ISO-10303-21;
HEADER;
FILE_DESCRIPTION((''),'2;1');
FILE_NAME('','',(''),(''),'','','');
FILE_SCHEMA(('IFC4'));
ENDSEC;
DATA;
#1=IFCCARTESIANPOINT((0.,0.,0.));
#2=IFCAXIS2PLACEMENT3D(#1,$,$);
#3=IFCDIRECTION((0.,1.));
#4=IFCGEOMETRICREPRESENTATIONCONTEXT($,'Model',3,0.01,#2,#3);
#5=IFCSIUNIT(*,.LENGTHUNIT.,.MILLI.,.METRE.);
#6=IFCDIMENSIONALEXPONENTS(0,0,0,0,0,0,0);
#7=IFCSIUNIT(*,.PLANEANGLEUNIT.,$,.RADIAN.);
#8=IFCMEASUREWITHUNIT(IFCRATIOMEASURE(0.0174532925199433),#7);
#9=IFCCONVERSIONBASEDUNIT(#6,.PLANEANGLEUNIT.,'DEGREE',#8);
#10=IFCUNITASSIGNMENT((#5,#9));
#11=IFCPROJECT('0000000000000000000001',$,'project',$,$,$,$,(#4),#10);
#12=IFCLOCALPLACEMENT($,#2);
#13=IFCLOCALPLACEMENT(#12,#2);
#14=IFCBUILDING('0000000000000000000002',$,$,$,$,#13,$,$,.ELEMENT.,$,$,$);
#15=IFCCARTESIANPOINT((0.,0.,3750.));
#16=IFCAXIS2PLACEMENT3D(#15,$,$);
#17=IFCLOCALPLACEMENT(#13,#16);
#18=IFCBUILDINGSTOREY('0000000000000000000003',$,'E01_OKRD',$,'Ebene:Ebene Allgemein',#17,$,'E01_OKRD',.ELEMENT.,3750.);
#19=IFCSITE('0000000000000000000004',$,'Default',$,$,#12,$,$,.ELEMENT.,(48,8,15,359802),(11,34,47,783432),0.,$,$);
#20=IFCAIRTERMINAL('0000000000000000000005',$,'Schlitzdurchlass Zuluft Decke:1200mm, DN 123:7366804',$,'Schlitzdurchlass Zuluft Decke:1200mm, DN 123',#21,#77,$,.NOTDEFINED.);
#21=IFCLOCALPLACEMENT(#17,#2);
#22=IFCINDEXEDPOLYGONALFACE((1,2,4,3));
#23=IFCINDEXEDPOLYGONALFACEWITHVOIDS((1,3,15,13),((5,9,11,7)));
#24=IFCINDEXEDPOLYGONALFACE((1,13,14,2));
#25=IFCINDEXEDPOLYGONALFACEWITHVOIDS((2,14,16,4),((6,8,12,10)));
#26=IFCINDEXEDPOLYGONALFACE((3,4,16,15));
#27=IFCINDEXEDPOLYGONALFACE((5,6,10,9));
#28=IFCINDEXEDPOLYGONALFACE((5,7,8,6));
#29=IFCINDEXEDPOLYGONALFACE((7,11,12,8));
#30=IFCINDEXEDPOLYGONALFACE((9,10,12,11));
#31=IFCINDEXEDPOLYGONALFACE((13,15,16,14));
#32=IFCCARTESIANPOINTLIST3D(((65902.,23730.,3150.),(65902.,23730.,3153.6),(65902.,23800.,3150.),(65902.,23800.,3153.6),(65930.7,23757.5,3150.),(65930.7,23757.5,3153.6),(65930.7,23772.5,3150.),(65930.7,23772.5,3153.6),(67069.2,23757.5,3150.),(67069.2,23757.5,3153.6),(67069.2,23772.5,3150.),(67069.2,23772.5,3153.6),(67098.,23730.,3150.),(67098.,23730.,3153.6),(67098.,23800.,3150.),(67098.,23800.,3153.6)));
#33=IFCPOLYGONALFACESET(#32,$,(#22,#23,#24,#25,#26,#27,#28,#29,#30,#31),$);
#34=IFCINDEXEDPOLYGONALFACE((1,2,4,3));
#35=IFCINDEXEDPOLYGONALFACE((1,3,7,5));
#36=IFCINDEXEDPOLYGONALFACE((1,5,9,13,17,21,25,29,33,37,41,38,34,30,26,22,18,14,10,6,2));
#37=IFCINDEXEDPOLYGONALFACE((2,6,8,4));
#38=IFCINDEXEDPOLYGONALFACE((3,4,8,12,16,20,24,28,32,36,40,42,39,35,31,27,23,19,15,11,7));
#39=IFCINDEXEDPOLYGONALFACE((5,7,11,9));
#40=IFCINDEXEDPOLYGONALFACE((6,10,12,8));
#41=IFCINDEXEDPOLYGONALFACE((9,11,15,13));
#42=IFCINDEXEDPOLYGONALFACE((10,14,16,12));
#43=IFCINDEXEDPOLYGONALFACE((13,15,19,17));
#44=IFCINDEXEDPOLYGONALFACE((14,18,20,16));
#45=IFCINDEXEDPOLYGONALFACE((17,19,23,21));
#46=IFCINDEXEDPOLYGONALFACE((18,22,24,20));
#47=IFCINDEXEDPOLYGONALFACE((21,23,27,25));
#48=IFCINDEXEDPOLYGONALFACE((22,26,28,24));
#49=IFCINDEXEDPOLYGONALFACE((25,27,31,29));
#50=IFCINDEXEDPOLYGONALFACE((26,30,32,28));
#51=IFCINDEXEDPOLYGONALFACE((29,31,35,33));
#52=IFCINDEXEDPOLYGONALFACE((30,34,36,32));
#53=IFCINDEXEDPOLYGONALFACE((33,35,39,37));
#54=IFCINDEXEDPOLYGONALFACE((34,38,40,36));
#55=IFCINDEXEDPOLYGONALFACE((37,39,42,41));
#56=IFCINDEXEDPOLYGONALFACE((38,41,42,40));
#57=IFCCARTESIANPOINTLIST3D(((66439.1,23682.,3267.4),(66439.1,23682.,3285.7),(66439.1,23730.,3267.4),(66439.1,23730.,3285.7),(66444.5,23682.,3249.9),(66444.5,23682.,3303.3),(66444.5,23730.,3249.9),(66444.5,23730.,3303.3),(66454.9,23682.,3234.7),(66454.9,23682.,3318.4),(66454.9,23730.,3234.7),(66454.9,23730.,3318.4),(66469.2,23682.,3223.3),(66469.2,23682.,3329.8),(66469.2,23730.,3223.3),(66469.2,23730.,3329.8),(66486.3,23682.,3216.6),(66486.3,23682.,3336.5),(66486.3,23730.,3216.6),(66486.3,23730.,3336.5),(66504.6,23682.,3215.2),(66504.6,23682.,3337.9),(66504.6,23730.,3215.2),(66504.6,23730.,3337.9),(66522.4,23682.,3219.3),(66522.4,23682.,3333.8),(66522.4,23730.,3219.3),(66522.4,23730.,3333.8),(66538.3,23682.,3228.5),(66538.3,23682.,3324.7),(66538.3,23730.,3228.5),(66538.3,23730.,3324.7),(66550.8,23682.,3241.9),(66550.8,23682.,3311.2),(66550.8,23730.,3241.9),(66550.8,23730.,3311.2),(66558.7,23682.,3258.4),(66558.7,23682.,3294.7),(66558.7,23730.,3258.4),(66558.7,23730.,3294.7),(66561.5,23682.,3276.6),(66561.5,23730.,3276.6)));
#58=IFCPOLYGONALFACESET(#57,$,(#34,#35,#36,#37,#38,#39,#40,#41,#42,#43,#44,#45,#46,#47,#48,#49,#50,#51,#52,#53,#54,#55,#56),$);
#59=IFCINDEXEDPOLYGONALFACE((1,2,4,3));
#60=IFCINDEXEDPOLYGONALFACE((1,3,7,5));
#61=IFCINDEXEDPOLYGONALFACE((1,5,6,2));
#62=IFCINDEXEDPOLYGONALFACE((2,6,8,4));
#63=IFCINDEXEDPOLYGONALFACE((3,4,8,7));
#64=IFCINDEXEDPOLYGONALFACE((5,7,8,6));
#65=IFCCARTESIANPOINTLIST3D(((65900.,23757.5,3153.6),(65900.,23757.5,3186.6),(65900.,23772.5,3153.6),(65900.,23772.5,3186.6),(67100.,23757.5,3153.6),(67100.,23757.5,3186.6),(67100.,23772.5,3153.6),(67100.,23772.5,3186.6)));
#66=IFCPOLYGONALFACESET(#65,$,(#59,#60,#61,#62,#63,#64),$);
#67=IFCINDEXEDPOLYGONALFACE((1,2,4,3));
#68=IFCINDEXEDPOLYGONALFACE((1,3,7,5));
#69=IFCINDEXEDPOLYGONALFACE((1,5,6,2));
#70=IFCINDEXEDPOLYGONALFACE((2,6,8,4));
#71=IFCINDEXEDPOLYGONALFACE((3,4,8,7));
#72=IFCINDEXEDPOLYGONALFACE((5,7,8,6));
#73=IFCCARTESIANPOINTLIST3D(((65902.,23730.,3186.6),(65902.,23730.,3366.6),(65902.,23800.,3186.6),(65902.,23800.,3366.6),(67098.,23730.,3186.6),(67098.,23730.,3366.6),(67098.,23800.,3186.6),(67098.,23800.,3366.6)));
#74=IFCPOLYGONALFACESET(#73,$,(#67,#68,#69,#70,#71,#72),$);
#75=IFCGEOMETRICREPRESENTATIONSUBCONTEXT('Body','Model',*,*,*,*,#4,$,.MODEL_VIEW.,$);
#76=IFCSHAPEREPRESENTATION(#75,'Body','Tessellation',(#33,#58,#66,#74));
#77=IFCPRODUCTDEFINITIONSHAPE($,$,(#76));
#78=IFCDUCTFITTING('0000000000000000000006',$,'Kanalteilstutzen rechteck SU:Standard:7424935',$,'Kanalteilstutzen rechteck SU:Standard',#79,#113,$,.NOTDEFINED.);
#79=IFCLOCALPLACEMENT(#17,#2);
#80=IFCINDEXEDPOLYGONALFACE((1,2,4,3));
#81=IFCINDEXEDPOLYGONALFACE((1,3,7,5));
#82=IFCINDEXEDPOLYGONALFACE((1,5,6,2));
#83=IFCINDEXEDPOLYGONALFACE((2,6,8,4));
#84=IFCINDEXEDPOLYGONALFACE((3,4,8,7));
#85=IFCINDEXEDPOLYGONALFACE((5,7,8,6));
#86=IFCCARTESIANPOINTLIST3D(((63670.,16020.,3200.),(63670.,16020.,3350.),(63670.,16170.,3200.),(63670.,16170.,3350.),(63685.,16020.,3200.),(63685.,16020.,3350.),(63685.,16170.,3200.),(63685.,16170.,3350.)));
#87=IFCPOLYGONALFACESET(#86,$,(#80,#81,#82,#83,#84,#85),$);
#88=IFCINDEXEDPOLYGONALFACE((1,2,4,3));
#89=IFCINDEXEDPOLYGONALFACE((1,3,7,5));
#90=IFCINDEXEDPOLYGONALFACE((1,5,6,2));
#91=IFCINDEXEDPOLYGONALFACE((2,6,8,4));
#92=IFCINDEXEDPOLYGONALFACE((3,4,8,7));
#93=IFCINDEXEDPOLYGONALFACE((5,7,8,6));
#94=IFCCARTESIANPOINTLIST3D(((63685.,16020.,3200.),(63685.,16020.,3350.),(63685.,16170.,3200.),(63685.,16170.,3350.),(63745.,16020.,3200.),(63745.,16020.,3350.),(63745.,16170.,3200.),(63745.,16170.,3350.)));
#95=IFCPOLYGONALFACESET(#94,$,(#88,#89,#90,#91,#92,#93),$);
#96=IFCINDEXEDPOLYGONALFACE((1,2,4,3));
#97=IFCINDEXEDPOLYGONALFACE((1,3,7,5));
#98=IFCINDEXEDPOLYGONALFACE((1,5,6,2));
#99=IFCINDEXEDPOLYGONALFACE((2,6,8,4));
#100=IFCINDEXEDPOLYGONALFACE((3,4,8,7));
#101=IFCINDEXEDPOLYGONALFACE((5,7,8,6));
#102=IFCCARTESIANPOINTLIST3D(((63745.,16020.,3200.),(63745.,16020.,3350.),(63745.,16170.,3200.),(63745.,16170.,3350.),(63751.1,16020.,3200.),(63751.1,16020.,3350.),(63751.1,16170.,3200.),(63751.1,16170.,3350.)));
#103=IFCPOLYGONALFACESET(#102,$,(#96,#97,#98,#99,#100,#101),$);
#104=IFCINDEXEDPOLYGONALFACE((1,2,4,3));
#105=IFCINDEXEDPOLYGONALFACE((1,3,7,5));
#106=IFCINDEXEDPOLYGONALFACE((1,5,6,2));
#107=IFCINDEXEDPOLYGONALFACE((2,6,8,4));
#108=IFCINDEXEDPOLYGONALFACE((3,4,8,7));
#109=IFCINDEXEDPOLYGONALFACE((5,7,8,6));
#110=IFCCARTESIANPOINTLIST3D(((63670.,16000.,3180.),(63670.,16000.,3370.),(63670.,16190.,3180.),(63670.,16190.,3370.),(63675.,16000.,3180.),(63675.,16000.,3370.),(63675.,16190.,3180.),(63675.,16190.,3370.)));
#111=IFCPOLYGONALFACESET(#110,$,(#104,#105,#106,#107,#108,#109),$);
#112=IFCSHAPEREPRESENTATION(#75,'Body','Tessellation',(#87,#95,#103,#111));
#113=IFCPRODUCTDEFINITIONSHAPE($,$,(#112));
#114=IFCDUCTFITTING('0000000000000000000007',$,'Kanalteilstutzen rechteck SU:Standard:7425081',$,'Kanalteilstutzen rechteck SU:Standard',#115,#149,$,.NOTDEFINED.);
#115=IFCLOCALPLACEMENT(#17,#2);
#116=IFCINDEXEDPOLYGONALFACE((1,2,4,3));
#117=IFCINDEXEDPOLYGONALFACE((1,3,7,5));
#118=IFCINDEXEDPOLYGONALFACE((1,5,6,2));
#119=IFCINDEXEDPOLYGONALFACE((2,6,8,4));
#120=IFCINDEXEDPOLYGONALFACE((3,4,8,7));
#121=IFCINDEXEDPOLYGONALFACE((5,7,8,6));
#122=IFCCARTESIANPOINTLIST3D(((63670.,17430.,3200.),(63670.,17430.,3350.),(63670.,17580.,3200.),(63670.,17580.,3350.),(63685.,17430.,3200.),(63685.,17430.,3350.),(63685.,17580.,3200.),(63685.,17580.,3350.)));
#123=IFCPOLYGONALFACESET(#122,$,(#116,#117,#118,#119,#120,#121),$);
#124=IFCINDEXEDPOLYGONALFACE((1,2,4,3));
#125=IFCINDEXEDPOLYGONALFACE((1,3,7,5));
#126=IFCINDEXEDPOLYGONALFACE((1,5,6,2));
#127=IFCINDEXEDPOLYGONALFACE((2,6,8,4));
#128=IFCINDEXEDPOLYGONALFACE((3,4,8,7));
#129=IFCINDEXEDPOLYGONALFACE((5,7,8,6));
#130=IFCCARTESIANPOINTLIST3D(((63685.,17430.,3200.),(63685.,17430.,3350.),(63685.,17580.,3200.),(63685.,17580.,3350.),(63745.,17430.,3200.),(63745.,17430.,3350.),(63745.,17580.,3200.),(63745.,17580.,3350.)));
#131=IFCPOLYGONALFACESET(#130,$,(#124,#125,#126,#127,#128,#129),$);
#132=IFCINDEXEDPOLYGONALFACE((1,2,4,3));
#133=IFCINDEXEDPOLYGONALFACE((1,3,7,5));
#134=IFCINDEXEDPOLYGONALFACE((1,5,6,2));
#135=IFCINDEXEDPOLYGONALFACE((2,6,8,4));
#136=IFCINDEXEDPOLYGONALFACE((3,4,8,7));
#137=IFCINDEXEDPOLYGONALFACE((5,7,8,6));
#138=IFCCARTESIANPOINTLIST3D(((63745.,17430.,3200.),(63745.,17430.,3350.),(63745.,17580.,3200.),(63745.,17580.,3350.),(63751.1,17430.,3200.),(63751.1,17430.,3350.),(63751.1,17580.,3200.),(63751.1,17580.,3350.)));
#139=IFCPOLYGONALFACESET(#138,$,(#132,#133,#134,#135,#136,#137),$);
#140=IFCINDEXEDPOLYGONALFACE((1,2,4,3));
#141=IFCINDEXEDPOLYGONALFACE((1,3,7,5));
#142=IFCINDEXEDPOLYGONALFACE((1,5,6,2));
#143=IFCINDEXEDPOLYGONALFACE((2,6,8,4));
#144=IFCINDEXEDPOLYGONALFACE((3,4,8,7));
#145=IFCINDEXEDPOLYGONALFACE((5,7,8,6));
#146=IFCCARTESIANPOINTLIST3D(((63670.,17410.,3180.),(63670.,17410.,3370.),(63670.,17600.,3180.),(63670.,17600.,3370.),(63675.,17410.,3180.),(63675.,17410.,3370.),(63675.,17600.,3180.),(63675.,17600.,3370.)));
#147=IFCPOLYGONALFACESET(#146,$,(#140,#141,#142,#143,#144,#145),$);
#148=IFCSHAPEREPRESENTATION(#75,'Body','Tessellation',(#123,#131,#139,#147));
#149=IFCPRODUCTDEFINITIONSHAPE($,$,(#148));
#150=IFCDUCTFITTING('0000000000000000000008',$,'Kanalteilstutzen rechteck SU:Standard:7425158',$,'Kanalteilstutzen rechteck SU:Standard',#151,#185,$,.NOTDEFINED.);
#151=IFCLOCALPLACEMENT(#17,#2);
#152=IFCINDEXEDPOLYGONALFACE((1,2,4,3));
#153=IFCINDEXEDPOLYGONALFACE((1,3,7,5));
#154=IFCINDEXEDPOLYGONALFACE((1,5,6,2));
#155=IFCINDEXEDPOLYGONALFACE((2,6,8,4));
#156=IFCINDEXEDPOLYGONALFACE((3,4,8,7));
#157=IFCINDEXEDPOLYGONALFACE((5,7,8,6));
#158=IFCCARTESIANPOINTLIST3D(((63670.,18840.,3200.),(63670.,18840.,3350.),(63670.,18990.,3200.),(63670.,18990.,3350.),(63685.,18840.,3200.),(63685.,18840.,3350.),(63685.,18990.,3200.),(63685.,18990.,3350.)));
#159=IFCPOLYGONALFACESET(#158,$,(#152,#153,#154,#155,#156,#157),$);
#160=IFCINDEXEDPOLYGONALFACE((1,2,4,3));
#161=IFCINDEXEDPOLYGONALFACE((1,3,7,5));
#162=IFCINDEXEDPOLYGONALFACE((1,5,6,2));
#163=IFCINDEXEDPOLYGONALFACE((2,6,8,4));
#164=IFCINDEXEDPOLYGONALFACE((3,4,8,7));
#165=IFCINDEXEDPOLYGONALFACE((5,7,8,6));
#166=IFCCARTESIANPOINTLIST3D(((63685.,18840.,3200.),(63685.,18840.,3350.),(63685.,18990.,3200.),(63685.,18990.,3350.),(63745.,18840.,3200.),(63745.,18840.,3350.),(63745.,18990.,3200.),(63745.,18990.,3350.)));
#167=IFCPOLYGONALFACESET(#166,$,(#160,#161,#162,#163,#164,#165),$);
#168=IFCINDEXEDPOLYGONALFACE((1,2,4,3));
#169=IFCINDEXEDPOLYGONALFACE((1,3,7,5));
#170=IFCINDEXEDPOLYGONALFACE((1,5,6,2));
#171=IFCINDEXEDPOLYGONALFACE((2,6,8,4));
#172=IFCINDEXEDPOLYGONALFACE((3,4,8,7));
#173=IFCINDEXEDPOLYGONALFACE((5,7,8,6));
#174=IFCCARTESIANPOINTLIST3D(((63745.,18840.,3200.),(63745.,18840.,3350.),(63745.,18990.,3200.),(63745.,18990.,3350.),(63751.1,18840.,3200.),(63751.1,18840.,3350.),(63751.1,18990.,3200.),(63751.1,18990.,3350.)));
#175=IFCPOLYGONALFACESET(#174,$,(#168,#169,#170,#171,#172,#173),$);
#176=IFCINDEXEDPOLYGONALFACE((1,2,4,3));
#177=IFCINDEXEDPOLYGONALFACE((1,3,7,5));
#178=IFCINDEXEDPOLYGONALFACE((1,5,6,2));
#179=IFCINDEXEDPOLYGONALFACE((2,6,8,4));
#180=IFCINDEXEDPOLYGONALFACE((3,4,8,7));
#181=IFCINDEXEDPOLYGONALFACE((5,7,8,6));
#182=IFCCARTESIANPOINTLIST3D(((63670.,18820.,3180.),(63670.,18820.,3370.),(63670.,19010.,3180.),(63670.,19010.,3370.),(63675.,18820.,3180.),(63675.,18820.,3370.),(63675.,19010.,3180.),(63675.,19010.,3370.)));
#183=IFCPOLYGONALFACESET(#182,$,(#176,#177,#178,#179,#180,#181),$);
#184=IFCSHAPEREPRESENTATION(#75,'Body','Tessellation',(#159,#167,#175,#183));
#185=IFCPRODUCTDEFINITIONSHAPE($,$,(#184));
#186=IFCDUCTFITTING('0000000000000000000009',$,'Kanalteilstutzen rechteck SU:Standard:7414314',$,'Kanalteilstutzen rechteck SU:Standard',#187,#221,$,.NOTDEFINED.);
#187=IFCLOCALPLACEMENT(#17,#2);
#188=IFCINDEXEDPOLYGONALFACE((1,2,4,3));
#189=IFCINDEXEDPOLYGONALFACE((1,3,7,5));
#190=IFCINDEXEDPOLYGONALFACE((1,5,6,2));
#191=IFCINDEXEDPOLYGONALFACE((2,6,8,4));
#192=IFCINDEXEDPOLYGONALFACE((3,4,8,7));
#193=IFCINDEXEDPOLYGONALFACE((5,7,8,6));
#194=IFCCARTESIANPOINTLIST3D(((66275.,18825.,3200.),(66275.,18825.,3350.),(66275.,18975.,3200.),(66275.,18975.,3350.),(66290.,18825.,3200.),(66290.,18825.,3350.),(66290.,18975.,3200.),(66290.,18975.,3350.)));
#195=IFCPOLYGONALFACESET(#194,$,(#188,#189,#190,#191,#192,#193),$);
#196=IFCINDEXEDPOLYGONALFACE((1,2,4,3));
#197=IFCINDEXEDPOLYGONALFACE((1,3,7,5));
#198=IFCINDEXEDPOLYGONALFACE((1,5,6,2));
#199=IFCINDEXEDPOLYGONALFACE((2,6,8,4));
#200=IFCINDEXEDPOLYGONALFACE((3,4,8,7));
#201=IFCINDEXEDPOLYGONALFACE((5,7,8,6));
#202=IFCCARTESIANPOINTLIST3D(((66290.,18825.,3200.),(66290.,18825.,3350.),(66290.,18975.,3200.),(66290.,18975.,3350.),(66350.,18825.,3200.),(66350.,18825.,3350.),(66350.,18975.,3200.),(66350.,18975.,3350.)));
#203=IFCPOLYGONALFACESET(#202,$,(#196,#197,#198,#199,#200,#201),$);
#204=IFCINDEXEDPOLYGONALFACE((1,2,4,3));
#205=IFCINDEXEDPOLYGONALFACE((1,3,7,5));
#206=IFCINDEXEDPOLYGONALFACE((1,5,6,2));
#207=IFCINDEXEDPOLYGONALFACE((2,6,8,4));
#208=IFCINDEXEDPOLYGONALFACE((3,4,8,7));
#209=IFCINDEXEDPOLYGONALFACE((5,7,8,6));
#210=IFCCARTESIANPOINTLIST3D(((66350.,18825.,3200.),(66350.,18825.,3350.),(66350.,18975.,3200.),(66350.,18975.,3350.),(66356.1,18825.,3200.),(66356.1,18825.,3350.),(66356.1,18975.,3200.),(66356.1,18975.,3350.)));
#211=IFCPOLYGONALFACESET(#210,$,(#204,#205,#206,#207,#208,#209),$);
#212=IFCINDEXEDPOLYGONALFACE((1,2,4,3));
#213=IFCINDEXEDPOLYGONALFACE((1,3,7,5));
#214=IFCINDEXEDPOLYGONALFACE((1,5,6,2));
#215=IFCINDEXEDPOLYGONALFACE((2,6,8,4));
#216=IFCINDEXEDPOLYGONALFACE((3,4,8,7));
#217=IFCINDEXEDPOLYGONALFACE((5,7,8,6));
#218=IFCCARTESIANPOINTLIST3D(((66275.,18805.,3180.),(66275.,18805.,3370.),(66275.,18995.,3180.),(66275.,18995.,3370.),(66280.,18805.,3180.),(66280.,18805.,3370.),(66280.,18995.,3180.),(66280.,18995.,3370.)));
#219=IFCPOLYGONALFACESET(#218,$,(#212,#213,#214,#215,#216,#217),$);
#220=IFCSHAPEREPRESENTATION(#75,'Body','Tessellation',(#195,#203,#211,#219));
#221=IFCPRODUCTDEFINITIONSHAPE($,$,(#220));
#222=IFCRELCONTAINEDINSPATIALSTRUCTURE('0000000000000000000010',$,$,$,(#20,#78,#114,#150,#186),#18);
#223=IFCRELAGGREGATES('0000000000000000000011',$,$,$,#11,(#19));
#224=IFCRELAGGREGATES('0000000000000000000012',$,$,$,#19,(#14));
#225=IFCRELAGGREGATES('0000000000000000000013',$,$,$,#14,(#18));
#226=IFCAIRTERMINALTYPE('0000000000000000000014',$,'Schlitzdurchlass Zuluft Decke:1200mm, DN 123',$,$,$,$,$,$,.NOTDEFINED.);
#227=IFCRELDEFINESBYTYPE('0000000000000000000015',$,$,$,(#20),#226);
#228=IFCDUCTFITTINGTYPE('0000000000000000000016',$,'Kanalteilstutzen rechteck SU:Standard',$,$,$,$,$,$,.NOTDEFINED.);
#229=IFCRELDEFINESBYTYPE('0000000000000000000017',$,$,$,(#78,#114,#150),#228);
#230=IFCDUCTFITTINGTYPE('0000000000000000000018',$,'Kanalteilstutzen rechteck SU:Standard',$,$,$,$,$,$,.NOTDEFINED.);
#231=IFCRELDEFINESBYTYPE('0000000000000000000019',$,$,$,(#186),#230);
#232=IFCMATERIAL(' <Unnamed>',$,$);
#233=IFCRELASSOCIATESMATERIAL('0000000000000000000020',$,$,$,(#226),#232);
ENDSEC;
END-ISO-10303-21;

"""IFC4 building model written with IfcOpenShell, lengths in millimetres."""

from ifc_helpers import new_model, entity, si_unit, converted_unit, direction, frame, frame_2d, origin, origin_2d_with_axis, place, context, subcontext, project, spatial, polyline, rectangle, circle, outline, extrude, source, transform, mapped, material, type_object, type_shapes, element, save


model = new_model("IFC4")

# Units and contexts
model_context = context("Model", 3, precision=0.01, world=origin(), true_north=direction((0.0, 1.0)))
body_context = subcontext(model_context, "Body", "Model", "MODEL_VIEW")
ifc_project = project(units=[si_unit("LENGTHUNIT", "METRE", prefix="MILLI"), converted_unit("PLANEANGLEUNIT", "DEGREE", entity("IfcRatioMeasure", 0.0174532925199433), si_unit("PLANEANGLEUNIT", "RADIAN"), dimensions=[0, 0, 0, 0, 0, 0, 0])], contexts=[model_context])

# Site, building, storey
site_placement = place(None, origin())
site = spatial("IfcSite", under=ifc_project, at=site_placement, Name="Default", CompositionType="ELEMENT", RefLatitude=(48, 8, 15, 359802), RefLongitude=(11, 34, 47, 783432), RefElevation=0.0)
building_placement = place(site_placement, origin())
building = spatial("IfcBuilding", under=site, at=building_placement, CompositionType="ELEMENT")
storey_placement = place(building_placement, frame((0.0, 0.0, 3750.0)))
storey = spatial("IfcBuildingStorey", under=building, at=storey_placement, Name="E01_OKRD", ObjectType="Ebene:Ebene Allgemein", LongName="E01_OKRD", CompositionType="ELEMENT", Elevation=3750.0)

# Air terminal
ifc_material_1 = material(Name=" <Unnamed>")
air_terminal_type_1 = type_object("IfcAirTerminalType", Name="Schlitzdurchlass Zuluft Decke:1200mm, DN 123", PredefinedType="NOTDEFINED", material=ifc_material_1)
shared_shape_1 = source(origin(), body_context, "Body", "SweptSolid", [
    extrude(outline(polyline([(-598.0, -35.0), (598.0, -35.0), (598.0, 35.0), (-598.0, 35.0), (-598.0, -35.0)]), holes=[polyline([(-569.2, -7.5), (-569.2, 7.5), (569.2, 7.5), (569.2, -7.5), (-569.2, -7.5)])]), frame((600.0, 35.0, 0.0), z_axis=(0.0, 0.0, 1.0), x_axis=(-1.0, 0.0, 0.0)), (0.0, 0.0, 1.0), 3.6),
    extrude(circle(Radius=61.5, at=frame_2d((0.0, 0.0), x_axis=(1.0, 0.0))), frame((600.0, 70.0, 126.6), z_axis=(0.0, 1.0, 0.0), x_axis=(-1.0, 0.0, 0.0)), (0.0, 0.0, 1.0), 48.0),
    extrude(rectangle(XDim=1200.0, YDim=15.0, at=origin_2d_with_axis()), frame((600.0, 35.0, 3.6), z_axis=(0.0, 0.0, 1.0), x_axis=(-1.0, 0.0, 0.0)), (0.0, 0.0, 1.0), 33.0),
    extrude(rectangle(XDim=1196.0, YDim=70.0, at=origin_2d_with_axis()), frame((600.0, 35.0, 36.6), z_axis=(0.0, 0.0, 1.0), x_axis=(-1.0, 0.0, 0.0)), (0.0, 0.0, 1.0), 180.0),
])
type_shapes(air_terminal_type_1, [shared_shape_1])
air_terminal_placement = place(storey_placement, frame((67100.0, 23800.0, 3150.0), z_axis=(0.0, 0.0, 1.0), x_axis=(-1.0, 0.0, 0.0)))
element("IfcAirTerminal", 1, at=air_terminal_placement, inside=storey, type_object=air_terminal_type_1, Name="Schlitzdurchlass Zuluft Decke:1200mm, DN 123:7366804", ObjectType="Schlitzdurchlass Zuluft Decke:1200mm, DN 123", PredefinedType="NOTDEFINED", context=body_context, shape_type="MappedRepresentation", body=[
    mapped(shared_shape_1, transform((0.0, 0.0, 0.0), scale=1.0)),
])

# Duct fittings
duct_fitting_type_1 = type_object("IfcDuctFittingType", Name="Kanalteilstutzen rechteck SU:Standard", PredefinedType="NOTDEFINED")
shared_shape_2 = source(origin(), body_context, "Body", "SweptSolid", [
    extrude(rectangle(XDim=150.0, YDim=15.0, at=origin_2d_with_axis()), frame((67.5, 0.0, -75.0), z_axis=(0.0, 0.0, 1.0), x_axis=(0.0, -1.0, 0.0)), (0.0, 0.0, 1.0), 150.0),
    extrude(rectangle(XDim=150.0, YDim=60.0, at=frame_2d((0.0, 0.0), x_axis=(1.0, 0.0))), frame((30.0, 0.0, -75.0), z_axis=(0.0, 0.0, 1.0), x_axis=(0.0, -1.0, 0.0)), (0.0, 0.0, 1.0), 150.0),
    extrude(rectangle(XDim=150.0, YDim=6.1, at=frame_2d((0.0, 0.0), x_axis=(1.0, 0.0))), frame((-3.0, 0.0, -75.0), z_axis=(0.0, 0.0, 1.0), x_axis=(0.0, -1.0, 0.0)), (0.0, 0.0, 1.0), 150.0),
    extrude(rectangle(XDim=190.0, YDim=5.0, at=origin_2d_with_axis()), frame((72.5, 0.0, -95.0), z_axis=(0.0, 0.0, 1.0), x_axis=(0.0, -1.0, 0.0)), (0.0, 0.0, 1.0), 190.0),
])
type_shapes(duct_fitting_type_1, [shared_shape_2])
for number, where, z_axis, x_axis, name in (
    (2, (63745.0, 16095.0, 3275.0), (0.0, 0.0, -1.0), (-1.0, 0.0, 0.0), "Kanalteilstutzen rechteck SU:Standard:7424935"),
    (3, (63745.0, 17505.0, 3275.0), (0.0, 0.0, -1.0), (-1.0, 0.0, 0.0), "Kanalteilstutzen rechteck SU:Standard:7425081"),
    (4, (63745.0, 18915.0, 3275.0), (0.0, 0.0, -1.0), (-1.0, 0.0, 0.0), "Kanalteilstutzen rechteck SU:Standard:7425158"),
):
    element("IfcDuctFitting", number, at=place(storey_placement, frame(where, z_axis=z_axis, x_axis=x_axis)), inside=storey, type_object=duct_fitting_type_1, Name=name, ObjectType="Kanalteilstutzen rechteck SU:Standard", PredefinedType="NOTDEFINED", context=body_context, shape_type="MappedRepresentation", body=[
        mapped(shared_shape_2, transform((0.0, 0.0, 0.0), scale=1.0)),
    ])
duct_fitting_type_2 = type_object("IfcDuctFittingType", Name="Kanalteilstutzen rechteck SU:Standard", PredefinedType="NOTDEFINED")
shared_shape_3 = source(origin(), body_context, "Body", "SweptSolid", [
    extrude(rectangle(XDim=15.0, YDim=150.0, at=frame_2d((0.0, 0.0), x_axis=(1.0, 0.0))), frame((67.5, 0.0, -75.0)), (0.0, 0.0, 1.0), 150.0),
    extrude(rectangle(XDim=60.0, YDim=150.0, at=frame_2d((0.0, 0.0), x_axis=(1.0, 0.0))), frame((30.0, 0.0, -75.0)), (0.0, 0.0, 1.0), 150.0),
    extrude(rectangle(XDim=6.1, YDim=150.0, at=frame_2d((0.0, 0.0), x_axis=(1.0, 0.0))), frame((-3.0, 0.0, -75.0)), (0.0, 0.0, 1.0), 150.0),
    extrude(rectangle(XDim=5.0, YDim=190.0, at=origin_2d_with_axis()), frame((72.5, 0.0, -95.0)), (0.0, 0.0, 1.0), 190.0),
])
type_shapes(duct_fitting_type_2, [shared_shape_3])
duct_fitting_1_placement = place(storey_placement, frame((66350.0, 18900.0, 3275.0), z_axis=(0.0, 0.0, -1.0), x_axis=(-1.0, 0.0, 0.0)))
element("IfcDuctFitting", 5, at=duct_fitting_1_placement, inside=storey, type_object=duct_fitting_type_2, Name="Kanalteilstutzen rechteck SU:Standard:7414314", ObjectType="Kanalteilstutzen rechteck SU:Standard", PredefinedType="NOTDEFINED", context=body_context, shape_type="MappedRepresentation", body=[
    mapped(shared_shape_3, transform((0.0, 0.0, 0.0), scale=1.0)),
])

save(model, "model.ifc")
